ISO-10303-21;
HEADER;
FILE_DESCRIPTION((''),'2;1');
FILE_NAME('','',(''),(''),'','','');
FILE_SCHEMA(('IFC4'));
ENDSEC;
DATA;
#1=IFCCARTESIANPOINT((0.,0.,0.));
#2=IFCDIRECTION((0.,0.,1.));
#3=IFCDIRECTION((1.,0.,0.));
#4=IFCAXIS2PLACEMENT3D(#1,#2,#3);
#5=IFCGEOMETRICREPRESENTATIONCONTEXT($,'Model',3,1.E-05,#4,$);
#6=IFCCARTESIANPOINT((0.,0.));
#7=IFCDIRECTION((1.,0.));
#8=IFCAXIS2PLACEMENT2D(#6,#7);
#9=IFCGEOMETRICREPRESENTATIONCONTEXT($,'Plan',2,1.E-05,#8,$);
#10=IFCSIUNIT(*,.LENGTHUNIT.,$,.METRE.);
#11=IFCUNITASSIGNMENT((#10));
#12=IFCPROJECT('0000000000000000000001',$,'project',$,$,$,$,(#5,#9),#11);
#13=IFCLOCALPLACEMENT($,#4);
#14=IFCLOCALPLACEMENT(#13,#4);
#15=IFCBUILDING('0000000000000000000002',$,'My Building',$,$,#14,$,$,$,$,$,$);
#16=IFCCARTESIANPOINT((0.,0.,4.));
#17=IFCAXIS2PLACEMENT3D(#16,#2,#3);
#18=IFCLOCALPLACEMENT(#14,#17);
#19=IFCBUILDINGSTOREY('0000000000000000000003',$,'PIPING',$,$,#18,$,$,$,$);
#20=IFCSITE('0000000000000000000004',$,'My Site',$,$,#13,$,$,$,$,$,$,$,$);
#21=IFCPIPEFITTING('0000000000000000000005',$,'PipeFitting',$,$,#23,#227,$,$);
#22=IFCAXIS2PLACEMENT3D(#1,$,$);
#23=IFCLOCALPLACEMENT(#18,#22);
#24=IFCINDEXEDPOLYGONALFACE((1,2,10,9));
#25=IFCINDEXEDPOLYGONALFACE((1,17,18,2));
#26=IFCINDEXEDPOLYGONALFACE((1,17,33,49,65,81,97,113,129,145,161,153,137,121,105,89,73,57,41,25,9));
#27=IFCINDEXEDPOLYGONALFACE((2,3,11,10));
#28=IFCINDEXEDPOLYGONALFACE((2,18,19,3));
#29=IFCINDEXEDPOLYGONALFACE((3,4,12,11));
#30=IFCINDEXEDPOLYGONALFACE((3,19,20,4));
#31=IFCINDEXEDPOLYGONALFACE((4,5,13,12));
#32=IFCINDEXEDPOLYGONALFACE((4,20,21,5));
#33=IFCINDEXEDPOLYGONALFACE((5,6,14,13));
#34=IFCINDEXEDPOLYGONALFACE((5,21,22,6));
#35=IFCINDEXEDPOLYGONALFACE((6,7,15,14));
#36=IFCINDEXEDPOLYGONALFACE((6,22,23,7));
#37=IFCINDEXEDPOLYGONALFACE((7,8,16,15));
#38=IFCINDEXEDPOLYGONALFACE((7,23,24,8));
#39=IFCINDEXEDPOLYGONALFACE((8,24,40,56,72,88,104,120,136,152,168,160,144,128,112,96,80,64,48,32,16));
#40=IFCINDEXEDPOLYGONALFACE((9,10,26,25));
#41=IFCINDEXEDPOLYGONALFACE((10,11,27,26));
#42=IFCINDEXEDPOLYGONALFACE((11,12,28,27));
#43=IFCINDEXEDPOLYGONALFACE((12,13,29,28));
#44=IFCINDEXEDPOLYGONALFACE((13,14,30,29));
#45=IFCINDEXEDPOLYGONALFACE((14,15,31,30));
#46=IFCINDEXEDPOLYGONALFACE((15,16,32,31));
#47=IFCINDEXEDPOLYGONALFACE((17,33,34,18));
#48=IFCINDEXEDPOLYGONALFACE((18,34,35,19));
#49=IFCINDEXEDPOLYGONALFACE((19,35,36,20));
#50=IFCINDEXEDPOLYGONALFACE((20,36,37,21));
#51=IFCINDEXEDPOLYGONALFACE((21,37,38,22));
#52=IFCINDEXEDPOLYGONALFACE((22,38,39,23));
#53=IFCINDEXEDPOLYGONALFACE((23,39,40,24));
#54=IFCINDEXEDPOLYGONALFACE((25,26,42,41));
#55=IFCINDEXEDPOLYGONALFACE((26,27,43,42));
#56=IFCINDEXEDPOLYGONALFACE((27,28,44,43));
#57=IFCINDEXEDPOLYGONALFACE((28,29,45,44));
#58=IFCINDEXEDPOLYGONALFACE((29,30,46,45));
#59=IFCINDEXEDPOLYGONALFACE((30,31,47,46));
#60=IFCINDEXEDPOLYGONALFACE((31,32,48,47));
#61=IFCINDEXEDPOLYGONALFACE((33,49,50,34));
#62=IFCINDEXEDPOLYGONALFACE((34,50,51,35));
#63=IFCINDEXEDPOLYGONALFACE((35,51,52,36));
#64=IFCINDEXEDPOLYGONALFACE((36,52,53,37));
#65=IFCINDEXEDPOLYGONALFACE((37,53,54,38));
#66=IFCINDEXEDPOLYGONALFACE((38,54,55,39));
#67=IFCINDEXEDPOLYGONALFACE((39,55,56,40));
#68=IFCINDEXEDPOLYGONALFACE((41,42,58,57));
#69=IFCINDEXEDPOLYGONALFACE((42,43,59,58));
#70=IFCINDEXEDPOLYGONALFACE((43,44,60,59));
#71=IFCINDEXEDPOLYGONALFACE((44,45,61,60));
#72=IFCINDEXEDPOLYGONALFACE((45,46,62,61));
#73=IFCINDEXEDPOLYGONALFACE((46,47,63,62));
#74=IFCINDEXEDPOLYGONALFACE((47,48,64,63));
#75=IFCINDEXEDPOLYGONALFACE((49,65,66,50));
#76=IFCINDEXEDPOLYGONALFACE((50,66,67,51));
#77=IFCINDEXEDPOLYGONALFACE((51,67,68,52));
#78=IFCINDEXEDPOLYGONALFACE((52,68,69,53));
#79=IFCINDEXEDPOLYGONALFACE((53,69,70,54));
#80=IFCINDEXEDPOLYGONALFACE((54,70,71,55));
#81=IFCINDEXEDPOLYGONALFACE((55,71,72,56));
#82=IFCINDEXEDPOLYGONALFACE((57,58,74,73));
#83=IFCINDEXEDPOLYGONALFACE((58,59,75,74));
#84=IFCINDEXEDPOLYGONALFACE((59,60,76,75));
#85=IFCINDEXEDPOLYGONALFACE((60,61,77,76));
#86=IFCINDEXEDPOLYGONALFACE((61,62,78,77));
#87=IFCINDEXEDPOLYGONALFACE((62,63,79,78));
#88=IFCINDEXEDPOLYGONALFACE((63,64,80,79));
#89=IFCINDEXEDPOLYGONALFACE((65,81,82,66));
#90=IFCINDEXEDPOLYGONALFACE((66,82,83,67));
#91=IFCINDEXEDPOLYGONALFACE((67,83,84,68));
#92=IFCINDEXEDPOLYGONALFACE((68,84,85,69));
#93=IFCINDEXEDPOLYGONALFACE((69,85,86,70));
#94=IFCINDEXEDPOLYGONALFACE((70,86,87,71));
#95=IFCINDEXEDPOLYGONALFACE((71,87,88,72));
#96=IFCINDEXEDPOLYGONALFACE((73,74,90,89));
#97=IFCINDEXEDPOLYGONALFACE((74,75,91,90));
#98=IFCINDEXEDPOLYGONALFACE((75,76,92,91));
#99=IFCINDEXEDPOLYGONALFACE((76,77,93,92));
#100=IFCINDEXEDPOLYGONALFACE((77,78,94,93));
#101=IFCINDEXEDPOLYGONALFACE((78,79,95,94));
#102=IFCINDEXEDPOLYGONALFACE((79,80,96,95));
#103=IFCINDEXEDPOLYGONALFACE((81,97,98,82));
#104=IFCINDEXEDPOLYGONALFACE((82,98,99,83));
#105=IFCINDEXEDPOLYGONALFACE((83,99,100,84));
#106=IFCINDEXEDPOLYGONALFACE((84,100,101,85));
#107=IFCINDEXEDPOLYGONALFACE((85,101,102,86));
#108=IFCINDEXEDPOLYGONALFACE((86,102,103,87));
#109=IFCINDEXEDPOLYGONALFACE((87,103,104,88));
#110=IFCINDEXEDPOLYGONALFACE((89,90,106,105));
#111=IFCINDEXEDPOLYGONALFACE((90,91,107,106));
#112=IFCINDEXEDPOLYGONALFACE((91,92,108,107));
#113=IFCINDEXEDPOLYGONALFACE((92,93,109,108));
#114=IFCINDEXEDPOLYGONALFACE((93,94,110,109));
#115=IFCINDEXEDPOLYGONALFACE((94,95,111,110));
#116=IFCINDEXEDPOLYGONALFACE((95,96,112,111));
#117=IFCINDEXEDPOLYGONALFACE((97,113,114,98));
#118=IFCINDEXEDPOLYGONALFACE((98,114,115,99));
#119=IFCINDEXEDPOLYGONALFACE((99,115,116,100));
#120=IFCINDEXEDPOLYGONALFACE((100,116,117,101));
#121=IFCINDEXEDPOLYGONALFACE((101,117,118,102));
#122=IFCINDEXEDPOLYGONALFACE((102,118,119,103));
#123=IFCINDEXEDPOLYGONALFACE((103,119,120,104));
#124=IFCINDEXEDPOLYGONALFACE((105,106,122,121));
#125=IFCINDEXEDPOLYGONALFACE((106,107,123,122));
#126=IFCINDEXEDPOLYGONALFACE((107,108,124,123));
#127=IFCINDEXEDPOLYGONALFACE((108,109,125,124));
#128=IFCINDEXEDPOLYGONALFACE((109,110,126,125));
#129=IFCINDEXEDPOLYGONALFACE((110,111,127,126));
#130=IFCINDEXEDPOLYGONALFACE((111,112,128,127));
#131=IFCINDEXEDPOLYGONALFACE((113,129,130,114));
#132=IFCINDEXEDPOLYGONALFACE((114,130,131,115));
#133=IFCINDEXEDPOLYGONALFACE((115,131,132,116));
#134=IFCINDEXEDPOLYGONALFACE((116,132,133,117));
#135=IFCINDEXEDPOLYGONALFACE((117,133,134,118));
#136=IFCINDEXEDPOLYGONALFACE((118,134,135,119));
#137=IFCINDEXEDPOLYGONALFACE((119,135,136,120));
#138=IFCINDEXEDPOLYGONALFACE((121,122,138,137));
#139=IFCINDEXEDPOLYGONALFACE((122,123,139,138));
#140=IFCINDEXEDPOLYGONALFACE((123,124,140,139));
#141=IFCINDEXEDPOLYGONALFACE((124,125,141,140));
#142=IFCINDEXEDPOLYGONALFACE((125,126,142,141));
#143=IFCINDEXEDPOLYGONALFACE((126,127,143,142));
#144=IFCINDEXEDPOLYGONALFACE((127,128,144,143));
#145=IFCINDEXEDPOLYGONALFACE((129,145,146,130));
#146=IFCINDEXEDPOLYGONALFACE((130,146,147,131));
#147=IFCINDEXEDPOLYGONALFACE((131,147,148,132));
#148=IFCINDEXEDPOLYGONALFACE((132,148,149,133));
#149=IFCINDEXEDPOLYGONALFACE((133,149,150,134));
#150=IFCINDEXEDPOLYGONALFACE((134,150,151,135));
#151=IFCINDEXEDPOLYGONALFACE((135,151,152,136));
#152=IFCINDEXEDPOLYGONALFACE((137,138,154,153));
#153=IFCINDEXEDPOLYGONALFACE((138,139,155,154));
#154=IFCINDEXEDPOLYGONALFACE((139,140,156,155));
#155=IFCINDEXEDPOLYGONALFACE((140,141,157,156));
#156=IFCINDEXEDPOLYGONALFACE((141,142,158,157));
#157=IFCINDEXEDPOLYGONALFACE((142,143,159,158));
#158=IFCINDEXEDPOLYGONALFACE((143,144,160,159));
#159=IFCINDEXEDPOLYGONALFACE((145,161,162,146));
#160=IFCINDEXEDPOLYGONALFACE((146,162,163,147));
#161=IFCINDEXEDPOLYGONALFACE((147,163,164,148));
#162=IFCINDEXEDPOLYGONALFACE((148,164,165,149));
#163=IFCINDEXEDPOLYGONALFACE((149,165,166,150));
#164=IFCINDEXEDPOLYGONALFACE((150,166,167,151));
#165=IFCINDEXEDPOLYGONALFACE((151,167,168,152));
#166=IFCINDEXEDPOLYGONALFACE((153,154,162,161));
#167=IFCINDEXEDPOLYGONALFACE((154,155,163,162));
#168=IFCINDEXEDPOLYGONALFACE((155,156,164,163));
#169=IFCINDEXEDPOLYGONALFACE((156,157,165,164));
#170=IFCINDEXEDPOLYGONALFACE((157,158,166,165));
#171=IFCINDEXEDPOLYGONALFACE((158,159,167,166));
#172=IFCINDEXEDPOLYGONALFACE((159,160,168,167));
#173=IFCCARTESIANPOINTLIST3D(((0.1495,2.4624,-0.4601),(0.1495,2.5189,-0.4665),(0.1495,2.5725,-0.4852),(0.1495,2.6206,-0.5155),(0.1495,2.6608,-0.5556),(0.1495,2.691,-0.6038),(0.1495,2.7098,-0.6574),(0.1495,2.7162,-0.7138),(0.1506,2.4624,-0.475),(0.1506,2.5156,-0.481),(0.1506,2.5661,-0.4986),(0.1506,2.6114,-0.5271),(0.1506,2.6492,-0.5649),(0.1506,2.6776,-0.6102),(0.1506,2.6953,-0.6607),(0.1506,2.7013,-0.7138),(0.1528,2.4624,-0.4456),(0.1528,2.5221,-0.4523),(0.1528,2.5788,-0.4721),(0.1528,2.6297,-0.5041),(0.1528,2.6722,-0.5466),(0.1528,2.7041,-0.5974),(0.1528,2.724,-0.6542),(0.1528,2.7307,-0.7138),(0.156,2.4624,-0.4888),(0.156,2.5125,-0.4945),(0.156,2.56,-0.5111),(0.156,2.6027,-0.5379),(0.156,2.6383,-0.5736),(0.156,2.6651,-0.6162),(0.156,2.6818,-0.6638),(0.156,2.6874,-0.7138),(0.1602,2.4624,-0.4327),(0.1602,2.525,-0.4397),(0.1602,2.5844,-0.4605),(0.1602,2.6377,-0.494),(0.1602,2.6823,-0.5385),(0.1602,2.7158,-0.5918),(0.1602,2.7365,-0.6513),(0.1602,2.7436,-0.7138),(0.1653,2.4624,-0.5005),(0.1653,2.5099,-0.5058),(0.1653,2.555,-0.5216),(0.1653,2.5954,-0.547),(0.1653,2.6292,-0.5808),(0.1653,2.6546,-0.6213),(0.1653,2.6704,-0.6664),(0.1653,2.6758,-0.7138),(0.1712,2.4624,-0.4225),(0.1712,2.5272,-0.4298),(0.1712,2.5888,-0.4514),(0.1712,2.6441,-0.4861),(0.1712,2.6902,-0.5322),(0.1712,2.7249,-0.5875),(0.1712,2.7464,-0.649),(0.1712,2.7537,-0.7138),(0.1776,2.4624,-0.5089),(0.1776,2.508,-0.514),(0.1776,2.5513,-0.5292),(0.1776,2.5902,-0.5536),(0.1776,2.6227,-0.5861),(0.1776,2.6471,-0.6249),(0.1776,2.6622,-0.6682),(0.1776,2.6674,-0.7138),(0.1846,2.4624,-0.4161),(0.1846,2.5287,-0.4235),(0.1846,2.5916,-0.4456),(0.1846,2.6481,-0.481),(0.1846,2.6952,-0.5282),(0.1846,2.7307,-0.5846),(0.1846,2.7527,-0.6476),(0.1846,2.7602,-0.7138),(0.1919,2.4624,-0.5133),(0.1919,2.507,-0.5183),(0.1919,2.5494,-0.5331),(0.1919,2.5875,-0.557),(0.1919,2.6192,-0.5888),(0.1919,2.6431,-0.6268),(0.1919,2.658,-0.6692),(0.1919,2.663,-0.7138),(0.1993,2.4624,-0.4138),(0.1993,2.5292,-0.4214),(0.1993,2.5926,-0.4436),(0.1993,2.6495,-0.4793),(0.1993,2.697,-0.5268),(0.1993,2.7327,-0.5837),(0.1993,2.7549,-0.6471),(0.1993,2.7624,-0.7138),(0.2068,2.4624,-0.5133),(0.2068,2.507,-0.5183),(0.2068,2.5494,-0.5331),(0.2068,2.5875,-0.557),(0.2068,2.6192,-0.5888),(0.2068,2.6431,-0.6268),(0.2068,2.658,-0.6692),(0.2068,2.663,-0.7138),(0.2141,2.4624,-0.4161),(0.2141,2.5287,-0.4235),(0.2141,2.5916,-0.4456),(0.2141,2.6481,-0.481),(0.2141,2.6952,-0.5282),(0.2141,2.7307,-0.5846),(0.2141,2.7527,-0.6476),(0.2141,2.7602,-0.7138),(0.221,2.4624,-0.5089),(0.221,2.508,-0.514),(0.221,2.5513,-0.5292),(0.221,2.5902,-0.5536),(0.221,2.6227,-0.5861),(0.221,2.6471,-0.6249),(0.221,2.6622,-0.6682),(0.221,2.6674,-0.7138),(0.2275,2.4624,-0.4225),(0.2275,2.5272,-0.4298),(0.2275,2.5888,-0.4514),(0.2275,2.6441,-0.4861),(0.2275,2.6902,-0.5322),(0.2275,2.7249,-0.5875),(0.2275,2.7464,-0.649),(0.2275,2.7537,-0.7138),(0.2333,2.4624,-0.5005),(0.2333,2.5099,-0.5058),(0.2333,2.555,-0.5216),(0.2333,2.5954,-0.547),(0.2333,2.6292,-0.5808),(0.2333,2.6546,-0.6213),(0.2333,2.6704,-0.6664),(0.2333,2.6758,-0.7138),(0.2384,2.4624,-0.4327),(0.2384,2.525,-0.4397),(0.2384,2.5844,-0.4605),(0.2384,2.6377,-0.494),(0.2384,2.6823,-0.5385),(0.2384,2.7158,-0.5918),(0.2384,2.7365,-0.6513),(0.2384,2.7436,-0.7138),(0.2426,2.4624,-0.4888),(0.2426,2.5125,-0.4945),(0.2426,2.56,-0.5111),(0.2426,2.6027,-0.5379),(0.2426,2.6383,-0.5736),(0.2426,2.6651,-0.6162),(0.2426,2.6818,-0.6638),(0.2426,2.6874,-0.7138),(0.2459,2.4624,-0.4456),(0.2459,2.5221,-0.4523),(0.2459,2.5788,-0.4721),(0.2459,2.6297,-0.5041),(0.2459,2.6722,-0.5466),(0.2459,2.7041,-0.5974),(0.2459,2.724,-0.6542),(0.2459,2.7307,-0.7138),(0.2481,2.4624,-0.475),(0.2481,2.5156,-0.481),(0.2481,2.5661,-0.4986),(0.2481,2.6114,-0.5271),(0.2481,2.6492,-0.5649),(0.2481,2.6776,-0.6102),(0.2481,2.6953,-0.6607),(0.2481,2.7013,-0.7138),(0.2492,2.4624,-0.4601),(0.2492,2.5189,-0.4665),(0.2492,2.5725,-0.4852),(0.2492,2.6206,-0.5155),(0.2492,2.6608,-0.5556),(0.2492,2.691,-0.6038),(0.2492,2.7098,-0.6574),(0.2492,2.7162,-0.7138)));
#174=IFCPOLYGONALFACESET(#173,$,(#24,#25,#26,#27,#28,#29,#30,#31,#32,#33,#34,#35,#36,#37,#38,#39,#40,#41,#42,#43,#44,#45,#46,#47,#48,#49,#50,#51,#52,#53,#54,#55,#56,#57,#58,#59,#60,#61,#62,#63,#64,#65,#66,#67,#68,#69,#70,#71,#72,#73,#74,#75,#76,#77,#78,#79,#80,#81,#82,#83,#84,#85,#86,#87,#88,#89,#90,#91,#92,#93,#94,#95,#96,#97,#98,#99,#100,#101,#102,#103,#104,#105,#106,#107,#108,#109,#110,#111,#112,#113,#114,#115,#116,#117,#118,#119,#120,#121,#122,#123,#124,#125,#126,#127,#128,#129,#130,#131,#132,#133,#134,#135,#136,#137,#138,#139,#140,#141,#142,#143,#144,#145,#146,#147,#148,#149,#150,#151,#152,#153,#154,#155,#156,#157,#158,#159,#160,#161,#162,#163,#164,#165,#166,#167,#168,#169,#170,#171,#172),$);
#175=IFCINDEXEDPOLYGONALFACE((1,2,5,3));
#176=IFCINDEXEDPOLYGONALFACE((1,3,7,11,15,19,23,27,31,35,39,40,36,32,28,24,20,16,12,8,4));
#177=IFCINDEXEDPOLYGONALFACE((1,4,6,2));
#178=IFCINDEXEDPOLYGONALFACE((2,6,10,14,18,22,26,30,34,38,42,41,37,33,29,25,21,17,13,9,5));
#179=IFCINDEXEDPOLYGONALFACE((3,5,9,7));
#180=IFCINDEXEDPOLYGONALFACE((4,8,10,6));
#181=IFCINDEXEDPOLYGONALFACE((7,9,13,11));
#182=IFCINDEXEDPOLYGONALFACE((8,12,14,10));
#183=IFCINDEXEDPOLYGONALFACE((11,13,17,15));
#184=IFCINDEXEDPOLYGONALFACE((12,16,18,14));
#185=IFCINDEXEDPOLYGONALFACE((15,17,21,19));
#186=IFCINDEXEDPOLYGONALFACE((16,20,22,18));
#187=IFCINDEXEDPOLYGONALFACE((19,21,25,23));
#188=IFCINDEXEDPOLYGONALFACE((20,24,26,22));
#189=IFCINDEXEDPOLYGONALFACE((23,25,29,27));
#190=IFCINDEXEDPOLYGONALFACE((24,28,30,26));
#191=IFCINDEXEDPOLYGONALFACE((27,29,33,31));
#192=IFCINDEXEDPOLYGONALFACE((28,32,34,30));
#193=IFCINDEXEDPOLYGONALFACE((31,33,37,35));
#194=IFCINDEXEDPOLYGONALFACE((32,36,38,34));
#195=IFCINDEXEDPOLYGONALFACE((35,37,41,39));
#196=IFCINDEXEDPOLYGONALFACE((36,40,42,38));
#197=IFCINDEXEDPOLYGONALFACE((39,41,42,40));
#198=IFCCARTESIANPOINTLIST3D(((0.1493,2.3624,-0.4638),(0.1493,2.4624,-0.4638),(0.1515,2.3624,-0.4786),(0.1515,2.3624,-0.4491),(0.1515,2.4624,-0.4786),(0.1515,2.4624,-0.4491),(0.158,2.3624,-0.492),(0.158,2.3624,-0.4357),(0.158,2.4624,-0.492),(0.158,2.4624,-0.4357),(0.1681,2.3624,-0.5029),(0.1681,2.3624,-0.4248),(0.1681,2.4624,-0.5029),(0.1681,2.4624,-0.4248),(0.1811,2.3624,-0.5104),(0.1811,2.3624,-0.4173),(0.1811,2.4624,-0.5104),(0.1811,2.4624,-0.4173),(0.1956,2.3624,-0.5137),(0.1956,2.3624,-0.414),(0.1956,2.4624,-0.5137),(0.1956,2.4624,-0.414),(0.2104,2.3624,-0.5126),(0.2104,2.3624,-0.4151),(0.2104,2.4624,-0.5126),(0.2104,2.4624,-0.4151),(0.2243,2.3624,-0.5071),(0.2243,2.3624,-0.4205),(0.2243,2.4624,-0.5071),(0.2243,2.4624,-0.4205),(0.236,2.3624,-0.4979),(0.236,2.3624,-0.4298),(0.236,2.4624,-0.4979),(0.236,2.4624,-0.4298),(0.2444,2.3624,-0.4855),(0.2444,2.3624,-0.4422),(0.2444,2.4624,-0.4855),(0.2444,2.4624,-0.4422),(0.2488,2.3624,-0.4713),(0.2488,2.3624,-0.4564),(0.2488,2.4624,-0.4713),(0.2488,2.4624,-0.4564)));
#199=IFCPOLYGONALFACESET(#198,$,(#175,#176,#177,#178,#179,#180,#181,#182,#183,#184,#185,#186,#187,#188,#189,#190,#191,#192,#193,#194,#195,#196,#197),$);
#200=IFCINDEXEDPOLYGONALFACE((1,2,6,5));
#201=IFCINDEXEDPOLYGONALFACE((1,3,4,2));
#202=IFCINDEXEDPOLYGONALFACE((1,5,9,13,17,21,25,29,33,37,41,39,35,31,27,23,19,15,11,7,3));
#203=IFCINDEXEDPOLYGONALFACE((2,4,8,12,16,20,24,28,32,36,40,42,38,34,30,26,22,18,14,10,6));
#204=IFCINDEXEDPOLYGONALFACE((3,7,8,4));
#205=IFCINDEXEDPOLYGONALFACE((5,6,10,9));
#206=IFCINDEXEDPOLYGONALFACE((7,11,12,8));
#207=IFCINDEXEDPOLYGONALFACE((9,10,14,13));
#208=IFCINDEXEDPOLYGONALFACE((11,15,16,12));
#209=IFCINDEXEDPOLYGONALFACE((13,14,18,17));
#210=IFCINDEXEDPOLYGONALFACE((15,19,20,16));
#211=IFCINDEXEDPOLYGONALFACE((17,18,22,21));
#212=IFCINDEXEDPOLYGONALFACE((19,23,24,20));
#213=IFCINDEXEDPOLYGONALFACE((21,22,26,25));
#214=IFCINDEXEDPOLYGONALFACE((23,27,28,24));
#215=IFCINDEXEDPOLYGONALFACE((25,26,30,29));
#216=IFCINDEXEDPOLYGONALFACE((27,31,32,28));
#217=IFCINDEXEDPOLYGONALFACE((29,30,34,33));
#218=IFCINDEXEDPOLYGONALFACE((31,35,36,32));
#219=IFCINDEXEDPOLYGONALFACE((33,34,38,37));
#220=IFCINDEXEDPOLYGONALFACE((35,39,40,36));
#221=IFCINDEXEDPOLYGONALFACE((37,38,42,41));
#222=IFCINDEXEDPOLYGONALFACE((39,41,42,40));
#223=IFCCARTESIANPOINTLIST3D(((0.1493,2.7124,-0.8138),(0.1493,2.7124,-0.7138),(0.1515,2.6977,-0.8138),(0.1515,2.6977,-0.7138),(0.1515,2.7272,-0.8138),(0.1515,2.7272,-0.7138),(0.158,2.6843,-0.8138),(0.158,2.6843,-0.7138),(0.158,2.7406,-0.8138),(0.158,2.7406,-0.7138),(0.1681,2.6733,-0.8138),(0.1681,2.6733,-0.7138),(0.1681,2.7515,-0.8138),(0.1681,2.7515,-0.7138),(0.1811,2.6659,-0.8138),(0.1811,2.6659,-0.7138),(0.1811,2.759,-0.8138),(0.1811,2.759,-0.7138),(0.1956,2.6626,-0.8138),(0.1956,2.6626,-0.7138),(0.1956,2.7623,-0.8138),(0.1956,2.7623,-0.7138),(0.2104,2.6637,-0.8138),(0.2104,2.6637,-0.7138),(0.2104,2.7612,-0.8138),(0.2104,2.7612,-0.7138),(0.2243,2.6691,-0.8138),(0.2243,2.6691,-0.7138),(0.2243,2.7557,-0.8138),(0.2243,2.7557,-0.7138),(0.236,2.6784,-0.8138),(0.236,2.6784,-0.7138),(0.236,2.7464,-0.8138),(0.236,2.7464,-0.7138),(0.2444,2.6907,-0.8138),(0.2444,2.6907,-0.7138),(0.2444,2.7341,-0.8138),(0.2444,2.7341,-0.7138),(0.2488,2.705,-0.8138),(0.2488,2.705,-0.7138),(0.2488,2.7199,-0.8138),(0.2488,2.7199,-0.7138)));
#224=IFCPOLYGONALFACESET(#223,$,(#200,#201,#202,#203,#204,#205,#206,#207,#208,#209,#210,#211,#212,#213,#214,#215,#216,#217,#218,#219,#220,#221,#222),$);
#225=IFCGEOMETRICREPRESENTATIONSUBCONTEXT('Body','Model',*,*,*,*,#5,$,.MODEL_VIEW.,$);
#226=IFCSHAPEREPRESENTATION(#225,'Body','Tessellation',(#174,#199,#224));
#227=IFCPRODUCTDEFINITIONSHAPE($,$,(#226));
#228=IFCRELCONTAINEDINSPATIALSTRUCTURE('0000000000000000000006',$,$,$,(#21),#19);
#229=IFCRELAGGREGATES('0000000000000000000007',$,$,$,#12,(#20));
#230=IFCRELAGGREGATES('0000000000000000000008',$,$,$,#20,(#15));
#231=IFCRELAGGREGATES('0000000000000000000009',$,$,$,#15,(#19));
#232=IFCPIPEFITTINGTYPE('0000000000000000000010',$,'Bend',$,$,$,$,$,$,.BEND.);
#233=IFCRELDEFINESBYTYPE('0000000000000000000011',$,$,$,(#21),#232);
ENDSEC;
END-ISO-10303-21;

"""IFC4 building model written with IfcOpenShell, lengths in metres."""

from ifc_helpers import new_model, entity, si_unit, frame, origin_with_axes, origin_2d_with_axis, place, context, subcontext, project, spatial, circle, extrude, source, transform, mapped, type_object, type_shapes, element, save


model = new_model("IFC4")

# Units and contexts
model_context = context("Model", 3, precision=1e-05, world=origin_with_axes())
plan_context = context("Plan", 2, precision=1e-05, world=origin_2d_with_axis())
body_context = subcontext(model_context, "Body", "Model", "MODEL_VIEW")
ifc_project = project(units=[si_unit("LENGTHUNIT", "METRE")], contexts=[model_context, plan_context])

# Site, building, storey
site_placement = place(None, origin_with_axes())
site = spatial("IfcSite", under=ifc_project, at=site_placement, Name="My Site")
building_placement = place(site_placement, origin_with_axes())
building = spatial("IfcBuilding", under=site, at=building_placement, Name="My Building")
storey_placement = place(building_placement, frame((0.0, 0.0, 4.0), z_axis=(0.0, 0.0, 1.0), x_axis=(1.0, 0.0, 0.0)))
storey = spatial("IfcBuildingStorey", under=building, at=storey_placement, Name="PIPING")

# Pipe fitting
pipe_fitting_type = type_object("IfcPipeFittingType", Name="Bend", PredefinedType="BEND")
shared_shape = source(origin_with_axes(), body_context, "Body", "SolidModel", [
    entity("IfcSweptDiskSolid", entity("IfcIndexedPolyCurve", entity("IfcCartesianPointList3D", [[0.0, 0.0, 0.1], [0.0, -0.0732, 0.2768], [0.0, -0.25, 0.35]]), [entity("IfcArcIndex", [1, 2, 3])]), 0.05),
    extrude(circle(Radius=0.05), origin_with_axes(), (0.0, 0.0, 1.0), 0.1),
    extrude(circle(Radius=0.05), frame((0.0, -0.25, 0.35), z_axis=(0.0, -1.0, 0.0), x_axis=(1.0, 0.0, 0.0)), (0.0, 0.0, 1.0), 0.1),
])
type_shapes(pipe_fitting_type, [shared_shape])
for number, where, z_axis, x_axis, name in (
    (1, (0.1993, 2.3624, -0.4638), (0.0, 1.0, 0.0), (-1.0, 0.0, 0.0), "PipeFitting"),
):
    element("IfcPipeFitting", number, at=place(storey_placement, frame(where, z_axis=z_axis, x_axis=x_axis)), inside=storey, type_object=pipe_fitting_type, Name=name, context=body_context, shape_type="MappedRepresentation", body=[
        mapped(shared_shape, transform((0.0, 0.0, 0.0), x_axis=(1.0, 0.0, 0.0), y_axis=(0.0, 1.0, 0.0), z_axis=(0.0, 0.0, 1.0), scale=1.0)),
    ])

save(model, "model.ifc")
